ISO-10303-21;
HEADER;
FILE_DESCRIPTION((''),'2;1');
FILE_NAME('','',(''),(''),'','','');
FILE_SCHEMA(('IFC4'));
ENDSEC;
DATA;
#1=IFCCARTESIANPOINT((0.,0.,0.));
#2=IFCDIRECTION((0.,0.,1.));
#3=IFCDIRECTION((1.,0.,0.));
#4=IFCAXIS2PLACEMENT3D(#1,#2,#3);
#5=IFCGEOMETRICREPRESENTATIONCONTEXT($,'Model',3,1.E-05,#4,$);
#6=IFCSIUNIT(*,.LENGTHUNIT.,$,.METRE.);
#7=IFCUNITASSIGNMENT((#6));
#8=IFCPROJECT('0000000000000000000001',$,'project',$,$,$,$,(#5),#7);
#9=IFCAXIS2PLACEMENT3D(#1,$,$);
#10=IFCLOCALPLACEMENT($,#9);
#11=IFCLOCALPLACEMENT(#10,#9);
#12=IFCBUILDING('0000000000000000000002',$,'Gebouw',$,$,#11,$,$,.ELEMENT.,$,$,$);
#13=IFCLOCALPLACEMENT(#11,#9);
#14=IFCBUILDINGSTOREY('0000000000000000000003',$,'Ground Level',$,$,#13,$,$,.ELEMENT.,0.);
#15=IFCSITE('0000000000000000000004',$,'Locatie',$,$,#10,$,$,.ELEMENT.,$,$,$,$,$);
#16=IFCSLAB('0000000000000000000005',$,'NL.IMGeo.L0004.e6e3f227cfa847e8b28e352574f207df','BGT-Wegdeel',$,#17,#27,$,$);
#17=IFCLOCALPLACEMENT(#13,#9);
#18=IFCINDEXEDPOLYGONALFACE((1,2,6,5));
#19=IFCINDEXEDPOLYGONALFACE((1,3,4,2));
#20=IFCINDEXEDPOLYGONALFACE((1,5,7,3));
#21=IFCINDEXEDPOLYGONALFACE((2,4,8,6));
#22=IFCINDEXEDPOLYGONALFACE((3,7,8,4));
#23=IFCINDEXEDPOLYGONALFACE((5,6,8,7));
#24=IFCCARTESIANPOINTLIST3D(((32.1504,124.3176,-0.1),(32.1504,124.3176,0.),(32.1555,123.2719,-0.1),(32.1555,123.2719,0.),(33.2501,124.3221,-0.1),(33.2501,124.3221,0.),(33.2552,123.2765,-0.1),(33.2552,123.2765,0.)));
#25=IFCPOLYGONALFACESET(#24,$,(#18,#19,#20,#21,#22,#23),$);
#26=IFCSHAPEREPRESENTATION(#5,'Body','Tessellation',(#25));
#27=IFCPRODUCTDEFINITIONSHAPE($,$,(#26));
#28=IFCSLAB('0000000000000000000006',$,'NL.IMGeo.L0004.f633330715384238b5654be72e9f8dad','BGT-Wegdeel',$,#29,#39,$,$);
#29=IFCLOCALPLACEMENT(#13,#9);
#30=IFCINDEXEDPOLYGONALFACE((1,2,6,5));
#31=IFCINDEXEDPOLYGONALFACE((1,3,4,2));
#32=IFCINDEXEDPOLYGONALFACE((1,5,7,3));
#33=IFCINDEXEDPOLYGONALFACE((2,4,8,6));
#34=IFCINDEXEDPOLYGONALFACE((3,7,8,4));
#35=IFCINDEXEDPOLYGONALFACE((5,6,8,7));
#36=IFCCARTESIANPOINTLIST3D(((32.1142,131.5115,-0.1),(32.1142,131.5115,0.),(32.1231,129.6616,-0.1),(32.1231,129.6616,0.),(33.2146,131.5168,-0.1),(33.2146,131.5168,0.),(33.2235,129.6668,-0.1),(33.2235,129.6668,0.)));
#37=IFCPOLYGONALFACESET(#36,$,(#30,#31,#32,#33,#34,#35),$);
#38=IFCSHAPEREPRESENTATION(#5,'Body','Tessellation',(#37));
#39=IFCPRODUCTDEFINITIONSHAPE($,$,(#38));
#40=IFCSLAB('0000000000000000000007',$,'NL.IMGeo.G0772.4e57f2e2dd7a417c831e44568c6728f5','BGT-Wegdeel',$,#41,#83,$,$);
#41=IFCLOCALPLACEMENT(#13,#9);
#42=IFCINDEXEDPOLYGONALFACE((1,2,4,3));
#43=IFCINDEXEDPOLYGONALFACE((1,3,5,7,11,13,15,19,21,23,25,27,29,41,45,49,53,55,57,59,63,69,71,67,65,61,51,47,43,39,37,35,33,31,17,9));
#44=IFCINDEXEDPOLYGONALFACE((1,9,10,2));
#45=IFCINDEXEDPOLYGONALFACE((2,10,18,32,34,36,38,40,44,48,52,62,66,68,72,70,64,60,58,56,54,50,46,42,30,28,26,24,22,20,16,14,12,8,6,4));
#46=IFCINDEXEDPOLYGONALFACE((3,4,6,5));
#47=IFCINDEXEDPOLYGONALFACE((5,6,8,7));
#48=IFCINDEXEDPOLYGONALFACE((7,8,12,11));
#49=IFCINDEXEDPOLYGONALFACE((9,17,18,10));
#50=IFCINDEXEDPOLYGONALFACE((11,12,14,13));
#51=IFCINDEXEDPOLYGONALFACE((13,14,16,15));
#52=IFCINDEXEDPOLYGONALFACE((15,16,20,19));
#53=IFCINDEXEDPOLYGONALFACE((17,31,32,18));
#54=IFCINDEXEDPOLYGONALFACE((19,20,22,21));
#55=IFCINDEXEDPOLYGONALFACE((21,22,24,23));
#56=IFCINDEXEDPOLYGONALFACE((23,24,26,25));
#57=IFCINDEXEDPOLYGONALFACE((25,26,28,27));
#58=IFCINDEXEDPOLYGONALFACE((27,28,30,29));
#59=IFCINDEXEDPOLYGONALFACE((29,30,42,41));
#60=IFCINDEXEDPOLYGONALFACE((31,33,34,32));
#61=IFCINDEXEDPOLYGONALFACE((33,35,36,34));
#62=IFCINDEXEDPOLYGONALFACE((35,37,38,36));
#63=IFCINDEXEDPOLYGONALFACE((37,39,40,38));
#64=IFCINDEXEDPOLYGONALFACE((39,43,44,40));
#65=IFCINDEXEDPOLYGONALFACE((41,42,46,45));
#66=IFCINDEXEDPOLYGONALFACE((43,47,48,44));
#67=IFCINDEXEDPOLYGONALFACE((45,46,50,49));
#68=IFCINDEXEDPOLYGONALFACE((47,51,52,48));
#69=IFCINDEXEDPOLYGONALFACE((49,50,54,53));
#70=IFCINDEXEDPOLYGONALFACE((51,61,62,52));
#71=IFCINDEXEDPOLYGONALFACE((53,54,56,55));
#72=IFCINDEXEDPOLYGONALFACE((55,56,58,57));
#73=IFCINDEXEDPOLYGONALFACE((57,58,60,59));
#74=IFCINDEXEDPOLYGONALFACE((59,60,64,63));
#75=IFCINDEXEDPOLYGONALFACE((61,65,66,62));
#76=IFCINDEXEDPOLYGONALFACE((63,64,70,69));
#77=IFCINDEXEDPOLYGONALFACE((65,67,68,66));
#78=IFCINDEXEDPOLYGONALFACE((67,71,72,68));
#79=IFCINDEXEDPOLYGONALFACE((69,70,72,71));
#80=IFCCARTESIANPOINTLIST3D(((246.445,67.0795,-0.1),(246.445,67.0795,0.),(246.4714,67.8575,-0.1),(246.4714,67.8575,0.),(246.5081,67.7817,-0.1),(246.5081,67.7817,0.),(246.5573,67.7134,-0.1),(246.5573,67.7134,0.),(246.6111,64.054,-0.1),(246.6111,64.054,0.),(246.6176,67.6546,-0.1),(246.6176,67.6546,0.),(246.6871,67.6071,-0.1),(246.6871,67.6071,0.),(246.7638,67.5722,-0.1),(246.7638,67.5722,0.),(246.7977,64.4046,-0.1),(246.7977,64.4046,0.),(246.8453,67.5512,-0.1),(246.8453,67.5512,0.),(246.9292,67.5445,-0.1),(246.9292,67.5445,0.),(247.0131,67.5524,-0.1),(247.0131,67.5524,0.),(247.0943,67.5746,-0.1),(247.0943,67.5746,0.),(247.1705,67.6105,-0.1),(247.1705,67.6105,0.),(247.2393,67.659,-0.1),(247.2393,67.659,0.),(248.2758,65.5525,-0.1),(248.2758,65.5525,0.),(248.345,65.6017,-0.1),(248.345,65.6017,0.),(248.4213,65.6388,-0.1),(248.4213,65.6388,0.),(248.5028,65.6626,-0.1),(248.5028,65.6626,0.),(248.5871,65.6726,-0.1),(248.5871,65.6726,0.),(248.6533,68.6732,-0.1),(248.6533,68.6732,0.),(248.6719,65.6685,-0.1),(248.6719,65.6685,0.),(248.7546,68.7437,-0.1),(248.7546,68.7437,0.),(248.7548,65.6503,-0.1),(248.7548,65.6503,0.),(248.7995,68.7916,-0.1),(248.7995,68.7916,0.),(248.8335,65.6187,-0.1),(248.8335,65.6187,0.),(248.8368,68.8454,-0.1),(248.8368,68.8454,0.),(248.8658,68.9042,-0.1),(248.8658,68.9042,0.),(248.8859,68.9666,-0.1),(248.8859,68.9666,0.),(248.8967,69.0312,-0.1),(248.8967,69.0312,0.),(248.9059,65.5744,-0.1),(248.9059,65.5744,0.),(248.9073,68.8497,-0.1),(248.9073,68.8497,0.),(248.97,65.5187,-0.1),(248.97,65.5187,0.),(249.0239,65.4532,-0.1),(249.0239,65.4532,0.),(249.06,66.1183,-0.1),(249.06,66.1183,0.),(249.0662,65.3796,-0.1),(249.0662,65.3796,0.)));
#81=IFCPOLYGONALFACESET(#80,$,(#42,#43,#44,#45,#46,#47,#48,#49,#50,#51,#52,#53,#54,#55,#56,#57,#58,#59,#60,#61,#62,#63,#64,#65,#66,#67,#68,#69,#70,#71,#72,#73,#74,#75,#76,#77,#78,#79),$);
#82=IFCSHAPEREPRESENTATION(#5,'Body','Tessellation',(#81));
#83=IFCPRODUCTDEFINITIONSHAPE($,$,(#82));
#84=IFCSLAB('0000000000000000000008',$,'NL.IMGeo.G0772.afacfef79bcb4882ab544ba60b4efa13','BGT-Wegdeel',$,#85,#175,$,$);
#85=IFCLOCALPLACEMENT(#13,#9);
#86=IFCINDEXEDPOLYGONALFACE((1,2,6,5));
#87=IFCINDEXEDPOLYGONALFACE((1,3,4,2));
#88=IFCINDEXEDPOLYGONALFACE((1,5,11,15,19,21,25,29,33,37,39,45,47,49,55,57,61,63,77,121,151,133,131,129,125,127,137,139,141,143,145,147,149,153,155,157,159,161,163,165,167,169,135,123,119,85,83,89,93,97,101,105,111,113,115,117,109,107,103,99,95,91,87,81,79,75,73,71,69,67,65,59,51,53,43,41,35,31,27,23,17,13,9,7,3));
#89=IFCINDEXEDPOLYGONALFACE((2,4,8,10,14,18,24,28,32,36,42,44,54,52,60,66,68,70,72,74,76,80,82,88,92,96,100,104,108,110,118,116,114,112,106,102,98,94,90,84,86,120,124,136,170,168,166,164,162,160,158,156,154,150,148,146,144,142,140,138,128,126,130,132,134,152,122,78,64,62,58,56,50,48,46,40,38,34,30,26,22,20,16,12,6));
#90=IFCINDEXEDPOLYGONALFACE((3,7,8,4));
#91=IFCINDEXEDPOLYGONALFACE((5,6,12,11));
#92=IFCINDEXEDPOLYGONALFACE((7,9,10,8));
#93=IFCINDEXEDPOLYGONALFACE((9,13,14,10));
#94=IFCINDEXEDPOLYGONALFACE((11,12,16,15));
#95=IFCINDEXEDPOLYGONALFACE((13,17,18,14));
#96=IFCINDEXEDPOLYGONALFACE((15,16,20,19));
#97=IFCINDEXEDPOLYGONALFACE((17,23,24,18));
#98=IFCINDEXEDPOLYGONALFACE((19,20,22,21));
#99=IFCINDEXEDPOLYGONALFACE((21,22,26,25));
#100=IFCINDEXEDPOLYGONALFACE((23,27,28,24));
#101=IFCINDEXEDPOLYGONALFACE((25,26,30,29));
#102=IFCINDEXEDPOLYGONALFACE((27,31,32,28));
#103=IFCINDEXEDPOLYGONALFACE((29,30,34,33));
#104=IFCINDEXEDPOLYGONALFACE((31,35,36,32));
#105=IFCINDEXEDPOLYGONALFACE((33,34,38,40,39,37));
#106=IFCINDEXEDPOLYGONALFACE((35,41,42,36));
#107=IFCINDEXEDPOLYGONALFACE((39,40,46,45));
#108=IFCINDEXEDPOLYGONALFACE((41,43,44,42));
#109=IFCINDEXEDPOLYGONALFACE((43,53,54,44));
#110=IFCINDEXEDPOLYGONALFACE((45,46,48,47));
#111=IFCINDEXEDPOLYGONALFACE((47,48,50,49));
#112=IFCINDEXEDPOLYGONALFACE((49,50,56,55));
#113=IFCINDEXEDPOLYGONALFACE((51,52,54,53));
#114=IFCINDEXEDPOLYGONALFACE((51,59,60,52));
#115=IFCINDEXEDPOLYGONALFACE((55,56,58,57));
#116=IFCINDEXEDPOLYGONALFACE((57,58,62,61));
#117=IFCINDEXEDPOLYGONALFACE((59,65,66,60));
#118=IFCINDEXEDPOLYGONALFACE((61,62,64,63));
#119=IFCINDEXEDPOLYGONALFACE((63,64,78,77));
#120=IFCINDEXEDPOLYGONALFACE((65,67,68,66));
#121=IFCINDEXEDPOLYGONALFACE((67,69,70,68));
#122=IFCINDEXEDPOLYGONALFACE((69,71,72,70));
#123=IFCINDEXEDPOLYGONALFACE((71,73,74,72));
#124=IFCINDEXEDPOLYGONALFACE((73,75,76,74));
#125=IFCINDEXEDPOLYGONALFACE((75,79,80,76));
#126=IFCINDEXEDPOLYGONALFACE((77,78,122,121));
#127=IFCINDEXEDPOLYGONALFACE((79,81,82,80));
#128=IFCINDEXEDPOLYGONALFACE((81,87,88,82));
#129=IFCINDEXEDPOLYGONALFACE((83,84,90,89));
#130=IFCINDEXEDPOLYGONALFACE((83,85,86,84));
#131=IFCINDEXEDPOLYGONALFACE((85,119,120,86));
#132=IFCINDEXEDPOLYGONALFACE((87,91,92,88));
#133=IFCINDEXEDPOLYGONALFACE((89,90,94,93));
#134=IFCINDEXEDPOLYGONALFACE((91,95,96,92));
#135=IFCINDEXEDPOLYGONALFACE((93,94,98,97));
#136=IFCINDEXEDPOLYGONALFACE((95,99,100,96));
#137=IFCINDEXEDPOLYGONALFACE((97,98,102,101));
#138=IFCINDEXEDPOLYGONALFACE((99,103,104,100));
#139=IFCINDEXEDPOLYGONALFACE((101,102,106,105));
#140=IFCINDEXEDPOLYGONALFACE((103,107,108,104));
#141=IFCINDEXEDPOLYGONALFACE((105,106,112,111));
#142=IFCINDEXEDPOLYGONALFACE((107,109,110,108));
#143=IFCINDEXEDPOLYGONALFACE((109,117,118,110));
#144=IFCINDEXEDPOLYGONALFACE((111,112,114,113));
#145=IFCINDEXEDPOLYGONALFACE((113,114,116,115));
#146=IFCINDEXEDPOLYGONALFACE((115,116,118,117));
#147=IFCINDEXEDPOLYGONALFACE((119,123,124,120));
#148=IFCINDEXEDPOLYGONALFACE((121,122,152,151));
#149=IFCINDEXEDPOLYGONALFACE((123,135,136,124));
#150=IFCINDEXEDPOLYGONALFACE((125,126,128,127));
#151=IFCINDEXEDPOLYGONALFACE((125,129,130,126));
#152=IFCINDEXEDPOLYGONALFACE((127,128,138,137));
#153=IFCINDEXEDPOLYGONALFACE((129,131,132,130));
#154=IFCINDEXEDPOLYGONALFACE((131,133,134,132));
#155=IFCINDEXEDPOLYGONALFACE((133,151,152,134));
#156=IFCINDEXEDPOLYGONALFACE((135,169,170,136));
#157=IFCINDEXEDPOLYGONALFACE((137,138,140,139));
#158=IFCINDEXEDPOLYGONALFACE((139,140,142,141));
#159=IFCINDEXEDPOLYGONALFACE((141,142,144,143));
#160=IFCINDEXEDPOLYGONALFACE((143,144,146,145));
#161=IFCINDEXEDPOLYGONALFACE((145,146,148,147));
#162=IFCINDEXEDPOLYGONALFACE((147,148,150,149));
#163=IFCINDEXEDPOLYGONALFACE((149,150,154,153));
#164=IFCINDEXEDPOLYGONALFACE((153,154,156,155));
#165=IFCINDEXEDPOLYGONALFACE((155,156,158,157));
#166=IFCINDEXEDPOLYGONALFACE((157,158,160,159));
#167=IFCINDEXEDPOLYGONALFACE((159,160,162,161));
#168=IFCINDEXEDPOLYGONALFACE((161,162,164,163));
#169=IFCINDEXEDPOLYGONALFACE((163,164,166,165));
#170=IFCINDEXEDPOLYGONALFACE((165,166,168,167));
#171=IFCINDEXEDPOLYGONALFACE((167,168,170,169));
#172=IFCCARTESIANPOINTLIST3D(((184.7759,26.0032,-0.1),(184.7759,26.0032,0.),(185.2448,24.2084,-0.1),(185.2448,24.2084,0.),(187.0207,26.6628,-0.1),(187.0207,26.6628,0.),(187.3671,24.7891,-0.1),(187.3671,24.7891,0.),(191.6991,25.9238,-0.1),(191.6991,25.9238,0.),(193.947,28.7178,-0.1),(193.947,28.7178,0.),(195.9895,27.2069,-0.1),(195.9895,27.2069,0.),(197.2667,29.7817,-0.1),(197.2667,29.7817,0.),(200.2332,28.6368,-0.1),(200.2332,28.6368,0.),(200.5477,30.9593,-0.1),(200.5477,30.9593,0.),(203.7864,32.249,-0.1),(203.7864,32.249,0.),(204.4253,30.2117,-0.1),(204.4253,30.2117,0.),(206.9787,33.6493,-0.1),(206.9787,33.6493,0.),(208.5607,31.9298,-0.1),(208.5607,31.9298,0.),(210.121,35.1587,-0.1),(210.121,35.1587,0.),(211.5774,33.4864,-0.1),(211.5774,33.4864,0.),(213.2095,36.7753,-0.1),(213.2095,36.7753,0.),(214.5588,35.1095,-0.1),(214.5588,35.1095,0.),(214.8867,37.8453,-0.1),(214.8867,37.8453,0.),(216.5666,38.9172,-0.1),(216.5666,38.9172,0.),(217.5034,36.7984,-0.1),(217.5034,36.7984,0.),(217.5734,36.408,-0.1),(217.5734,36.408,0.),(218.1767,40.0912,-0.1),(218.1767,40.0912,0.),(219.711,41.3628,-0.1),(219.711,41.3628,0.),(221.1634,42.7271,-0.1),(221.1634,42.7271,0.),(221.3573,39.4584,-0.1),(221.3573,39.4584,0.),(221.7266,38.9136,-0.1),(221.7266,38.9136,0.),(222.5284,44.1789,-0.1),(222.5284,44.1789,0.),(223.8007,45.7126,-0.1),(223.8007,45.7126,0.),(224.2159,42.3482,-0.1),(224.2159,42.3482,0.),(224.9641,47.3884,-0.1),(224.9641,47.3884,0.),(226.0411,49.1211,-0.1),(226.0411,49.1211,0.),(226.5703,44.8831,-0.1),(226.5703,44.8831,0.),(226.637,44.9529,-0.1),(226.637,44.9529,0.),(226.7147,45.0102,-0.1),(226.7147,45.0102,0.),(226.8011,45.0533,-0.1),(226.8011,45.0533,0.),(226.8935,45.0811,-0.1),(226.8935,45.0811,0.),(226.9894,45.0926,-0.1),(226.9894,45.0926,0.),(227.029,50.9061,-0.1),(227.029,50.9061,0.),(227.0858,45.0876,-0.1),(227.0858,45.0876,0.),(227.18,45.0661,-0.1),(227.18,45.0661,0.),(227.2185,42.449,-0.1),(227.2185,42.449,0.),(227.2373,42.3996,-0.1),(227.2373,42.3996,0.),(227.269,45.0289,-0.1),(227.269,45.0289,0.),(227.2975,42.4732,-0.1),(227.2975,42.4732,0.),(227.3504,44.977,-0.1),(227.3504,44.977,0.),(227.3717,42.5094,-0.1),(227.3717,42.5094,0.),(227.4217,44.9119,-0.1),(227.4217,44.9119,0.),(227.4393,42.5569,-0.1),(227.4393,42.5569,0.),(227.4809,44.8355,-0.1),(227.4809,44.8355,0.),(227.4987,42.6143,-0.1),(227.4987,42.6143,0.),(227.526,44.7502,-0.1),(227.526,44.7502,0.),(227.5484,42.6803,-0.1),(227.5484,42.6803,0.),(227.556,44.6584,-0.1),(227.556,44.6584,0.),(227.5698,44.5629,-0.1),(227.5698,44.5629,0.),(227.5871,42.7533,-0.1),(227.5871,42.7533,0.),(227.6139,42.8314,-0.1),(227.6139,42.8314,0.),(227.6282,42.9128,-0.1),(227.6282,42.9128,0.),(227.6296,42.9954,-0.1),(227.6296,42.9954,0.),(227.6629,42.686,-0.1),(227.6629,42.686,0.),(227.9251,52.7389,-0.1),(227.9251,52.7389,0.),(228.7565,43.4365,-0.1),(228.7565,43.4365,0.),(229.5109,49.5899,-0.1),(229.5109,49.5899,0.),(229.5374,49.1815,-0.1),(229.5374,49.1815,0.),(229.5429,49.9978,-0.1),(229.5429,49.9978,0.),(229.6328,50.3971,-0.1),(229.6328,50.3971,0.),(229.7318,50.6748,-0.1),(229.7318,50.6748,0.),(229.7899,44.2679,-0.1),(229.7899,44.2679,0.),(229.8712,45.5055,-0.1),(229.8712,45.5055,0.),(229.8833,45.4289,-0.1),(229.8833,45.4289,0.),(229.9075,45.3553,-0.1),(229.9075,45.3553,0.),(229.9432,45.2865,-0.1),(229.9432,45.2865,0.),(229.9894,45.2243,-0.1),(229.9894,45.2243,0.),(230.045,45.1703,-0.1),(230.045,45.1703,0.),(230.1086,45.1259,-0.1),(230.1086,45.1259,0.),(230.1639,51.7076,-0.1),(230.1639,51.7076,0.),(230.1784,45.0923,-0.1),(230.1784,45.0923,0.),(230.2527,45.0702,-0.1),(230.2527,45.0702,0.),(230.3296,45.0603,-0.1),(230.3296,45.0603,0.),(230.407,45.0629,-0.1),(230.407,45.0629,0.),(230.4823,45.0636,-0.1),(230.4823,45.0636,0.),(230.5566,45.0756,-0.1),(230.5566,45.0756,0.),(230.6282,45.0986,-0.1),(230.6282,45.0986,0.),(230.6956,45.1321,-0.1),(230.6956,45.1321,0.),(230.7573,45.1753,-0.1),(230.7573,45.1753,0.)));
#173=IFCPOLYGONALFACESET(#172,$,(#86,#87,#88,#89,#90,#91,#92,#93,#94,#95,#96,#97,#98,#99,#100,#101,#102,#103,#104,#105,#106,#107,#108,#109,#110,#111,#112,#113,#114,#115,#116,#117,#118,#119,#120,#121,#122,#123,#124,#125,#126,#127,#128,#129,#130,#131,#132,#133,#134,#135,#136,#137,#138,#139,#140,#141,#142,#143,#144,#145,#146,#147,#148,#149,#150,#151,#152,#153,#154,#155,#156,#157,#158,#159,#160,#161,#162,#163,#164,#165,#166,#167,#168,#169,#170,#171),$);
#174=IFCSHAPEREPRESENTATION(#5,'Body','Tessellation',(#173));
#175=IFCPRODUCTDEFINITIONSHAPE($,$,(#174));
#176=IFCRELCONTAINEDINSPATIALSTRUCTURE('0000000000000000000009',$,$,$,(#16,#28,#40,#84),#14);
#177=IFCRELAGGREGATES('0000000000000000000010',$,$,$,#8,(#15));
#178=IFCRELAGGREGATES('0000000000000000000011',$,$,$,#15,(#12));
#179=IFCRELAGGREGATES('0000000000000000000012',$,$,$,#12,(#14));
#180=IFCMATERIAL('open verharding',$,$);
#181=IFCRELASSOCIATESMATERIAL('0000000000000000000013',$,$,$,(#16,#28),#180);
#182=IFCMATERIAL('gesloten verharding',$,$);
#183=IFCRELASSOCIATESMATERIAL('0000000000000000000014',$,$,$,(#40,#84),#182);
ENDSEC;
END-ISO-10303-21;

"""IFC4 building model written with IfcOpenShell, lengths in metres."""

from ifc_helpers import new_model, si_unit, frame, origin, origin_with_axes, place, context, project, spatial, polyline, outline, extrude, material, element, save


model = new_model("IFC4")

# Units and contexts
model_context = context("Model", 3, precision=1e-05, world=origin_with_axes())
ifc_project = project(units=[si_unit("LENGTHUNIT", "METRE")], contexts=[model_context])

# Site, building, storey
site_placement = place(None, origin())
site = spatial("IfcSite", under=ifc_project, at=site_placement, Name="Locatie", CompositionType="ELEMENT")
building_placement = place(site_placement, origin())
building = spatial("IfcBuilding", under=site, at=building_placement, Name="Gebouw", CompositionType="ELEMENT")
storey_placement = place(building_placement, origin())
storey = spatial("IfcBuildingStorey", under=building, at=storey_placement, Name="Ground Level", CompositionType="ELEMENT", Elevation=0.0)

# Slabs
ifc_material_1 = material(Name="open verharding")
ifc_material_2 = material(Name="gesloten verharding")
slab_1_placement = place(storey_placement, origin())
element("IfcSlab", 1, at=slab_1_placement, inside=storey, material=ifc_material_1, Name="NL.IMGeo.L0004.e6e3f227cfa847e8b28e352574f207df", Description="BGT-Wegdeel", context=model_context, shape_type="SweptSolid", body=[
    extrude(outline(polyline([(33.2501, 124.3221), (33.2552, 123.2765), (32.1555, 123.2719), (32.1504, 124.3176), (33.2501, 124.3221)])), frame((0.0, 0.0, -0.1), z_axis=(0.0, 0.0, 1.0), x_axis=(1.0, 0.0, 0.0)), (0.0, 0.0, 1.0), 0.1),
])
slab_2_placement = place(storey_placement, origin())
element("IfcSlab", 2, at=slab_2_placement, inside=storey, material=ifc_material_1, Name="NL.IMGeo.L0004.f633330715384238b5654be72e9f8dad", Description="BGT-Wegdeel", context=model_context, shape_type="SweptSolid", body=[
    extrude(outline(polyline([(33.2235, 129.6668), (32.1231, 129.6616), (32.1142, 131.5115), (33.2146, 131.5168), (33.2235, 129.6668)])), frame((0.0, 0.0, -0.1), z_axis=(0.0, 0.0, 1.0), x_axis=(1.0, 0.0, 0.0)), (0.0, 0.0, 1.0), 0.1),
])
slab_3_placement = place(storey_placement, origin())
element("IfcSlab", 3, at=slab_3_placement, inside=storey, material=ifc_material_2, Name="NL.IMGeo.G0772.4e57f2e2dd7a417c831e44568c6728f5", Description="BGT-Wegdeel", context=model_context, shape_type="SweptSolid", body=[
    extrude(outline(polyline([(249.06, 66.1183), (249.0662, 65.3796), (249.0239, 65.4532), (248.97, 65.5187), (248.9059, 65.5744), (248.8335, 65.6187), (248.7548, 65.6503), (248.6719, 65.6685), (248.5871, 65.6726), (248.5028, 65.6626), (248.4213, 65.6388), (248.345, 65.6017), (248.2758, 65.5525), (246.7977, 64.4046), (246.6111, 64.054), (246.445, 67.0795), (246.4714, 67.8575), (246.5081, 67.7817), (246.5573, 67.7134), (246.6176, 67.6546), (246.6871, 67.6071), (246.7638, 67.5722), (246.8453, 67.5512), (246.9292, 67.5445), (247.0131, 67.5524), (247.0943, 67.5746), (247.1705, 67.6105), (247.2393, 67.659), (248.6533, 68.6732), (248.7546, 68.7437), (248.7995, 68.7916), (248.8368, 68.8454), (248.8658, 68.9042), (248.8859, 68.9666), (248.8967, 69.0312), (248.9073, 68.8497), (249.06, 66.1183)])), frame((0.0, 0.0, -0.1), z_axis=(0.0, 0.0, 1.0), x_axis=(1.0, 0.0, 0.0)), (0.0, 0.0, 1.0), 0.1),
])
slab_4_placement = place(storey_placement, origin())
element("IfcSlab", 4, at=slab_4_placement, inside=storey, material=ifc_material_2, Name="NL.IMGeo.G0772.afacfef79bcb4882ab544ba60b4efa13", Description="BGT-Wegdeel", context=model_context, shape_type="SweptSolid", body=[
    extrude(outline(polyline([(216.5666, 38.9172), (218.1767, 40.0912), (219.711, 41.3628), (221.1634, 42.7271), (222.5284, 44.1789), (223.8007, 45.7126), (224.9641, 47.3884), (226.0411, 49.1211), (227.029, 50.9061), (227.9251, 52.7389), (230.1639, 51.7076), (229.7318, 50.6748), (229.6328, 50.3971), (229.5429, 49.9978), (229.5109, 49.5899), (229.5374, 49.1815), (229.8712, 45.5055), (229.8833, 45.4289), (229.9075, 45.3553), (229.9432, 45.2865), (229.9894, 45.2243), (230.045, 45.1703), (230.1086, 45.1259), (230.1784, 45.0923), (230.2527, 45.0702), (230.3296, 45.0603), (230.407, 45.0629), (230.4823, 45.0636), (230.5566, 45.0756), (230.6282, 45.0986), (230.6956, 45.1321), (230.7573, 45.1753), (229.7899, 44.2679), (228.7565, 43.4365), (227.6629, 42.686), (227.2373, 42.3996), (227.2185, 42.449), (227.2975, 42.4732), (227.3717, 42.5094), (227.4393, 42.5569), (227.4987, 42.6143), (227.5484, 42.6803), (227.5871, 42.7533), (227.6139, 42.8314), (227.6282, 42.9128), (227.6296, 42.9954), (227.5698, 44.5629), (227.556, 44.6584), (227.526, 44.7502), (227.4809, 44.8355), (227.4217, 44.9119), (227.3504, 44.977), (227.269, 45.0289), (227.18, 45.0661), (227.0858, 45.0876), (226.9894, 45.0926), (226.8935, 45.0811), (226.8011, 45.0533), (226.7147, 45.0102), (226.637, 44.9529), (226.5703, 44.8831), (224.2159, 42.3482), (221.3573, 39.4584), (221.7266, 38.9136), (217.5734, 36.408), (217.5034, 36.7984), (214.5588, 35.1095), (211.5774, 33.4864), (208.5607, 31.9298), (204.4253, 30.2117), (200.2332, 28.6368), (195.9895, 27.2069), (191.6991, 25.9238), (187.3671, 24.7891), (185.2448, 24.2084), (184.7759, 26.0032), (187.0207, 26.6628), (193.947, 28.7178), (197.2667, 29.7817), (200.5477, 30.9593), (203.7864, 32.249), (206.9787, 33.6493), (210.121, 35.1587), (213.2095, 36.7753), (214.8867, 37.8453), (216.5666, 38.9172)])), frame((0.0, 0.0, -0.1), z_axis=(0.0, 0.0, 1.0), x_axis=(1.0, 0.0, 0.0)), (0.0, 0.0, 1.0), 0.1),
])

save(model, "model.ifc")
